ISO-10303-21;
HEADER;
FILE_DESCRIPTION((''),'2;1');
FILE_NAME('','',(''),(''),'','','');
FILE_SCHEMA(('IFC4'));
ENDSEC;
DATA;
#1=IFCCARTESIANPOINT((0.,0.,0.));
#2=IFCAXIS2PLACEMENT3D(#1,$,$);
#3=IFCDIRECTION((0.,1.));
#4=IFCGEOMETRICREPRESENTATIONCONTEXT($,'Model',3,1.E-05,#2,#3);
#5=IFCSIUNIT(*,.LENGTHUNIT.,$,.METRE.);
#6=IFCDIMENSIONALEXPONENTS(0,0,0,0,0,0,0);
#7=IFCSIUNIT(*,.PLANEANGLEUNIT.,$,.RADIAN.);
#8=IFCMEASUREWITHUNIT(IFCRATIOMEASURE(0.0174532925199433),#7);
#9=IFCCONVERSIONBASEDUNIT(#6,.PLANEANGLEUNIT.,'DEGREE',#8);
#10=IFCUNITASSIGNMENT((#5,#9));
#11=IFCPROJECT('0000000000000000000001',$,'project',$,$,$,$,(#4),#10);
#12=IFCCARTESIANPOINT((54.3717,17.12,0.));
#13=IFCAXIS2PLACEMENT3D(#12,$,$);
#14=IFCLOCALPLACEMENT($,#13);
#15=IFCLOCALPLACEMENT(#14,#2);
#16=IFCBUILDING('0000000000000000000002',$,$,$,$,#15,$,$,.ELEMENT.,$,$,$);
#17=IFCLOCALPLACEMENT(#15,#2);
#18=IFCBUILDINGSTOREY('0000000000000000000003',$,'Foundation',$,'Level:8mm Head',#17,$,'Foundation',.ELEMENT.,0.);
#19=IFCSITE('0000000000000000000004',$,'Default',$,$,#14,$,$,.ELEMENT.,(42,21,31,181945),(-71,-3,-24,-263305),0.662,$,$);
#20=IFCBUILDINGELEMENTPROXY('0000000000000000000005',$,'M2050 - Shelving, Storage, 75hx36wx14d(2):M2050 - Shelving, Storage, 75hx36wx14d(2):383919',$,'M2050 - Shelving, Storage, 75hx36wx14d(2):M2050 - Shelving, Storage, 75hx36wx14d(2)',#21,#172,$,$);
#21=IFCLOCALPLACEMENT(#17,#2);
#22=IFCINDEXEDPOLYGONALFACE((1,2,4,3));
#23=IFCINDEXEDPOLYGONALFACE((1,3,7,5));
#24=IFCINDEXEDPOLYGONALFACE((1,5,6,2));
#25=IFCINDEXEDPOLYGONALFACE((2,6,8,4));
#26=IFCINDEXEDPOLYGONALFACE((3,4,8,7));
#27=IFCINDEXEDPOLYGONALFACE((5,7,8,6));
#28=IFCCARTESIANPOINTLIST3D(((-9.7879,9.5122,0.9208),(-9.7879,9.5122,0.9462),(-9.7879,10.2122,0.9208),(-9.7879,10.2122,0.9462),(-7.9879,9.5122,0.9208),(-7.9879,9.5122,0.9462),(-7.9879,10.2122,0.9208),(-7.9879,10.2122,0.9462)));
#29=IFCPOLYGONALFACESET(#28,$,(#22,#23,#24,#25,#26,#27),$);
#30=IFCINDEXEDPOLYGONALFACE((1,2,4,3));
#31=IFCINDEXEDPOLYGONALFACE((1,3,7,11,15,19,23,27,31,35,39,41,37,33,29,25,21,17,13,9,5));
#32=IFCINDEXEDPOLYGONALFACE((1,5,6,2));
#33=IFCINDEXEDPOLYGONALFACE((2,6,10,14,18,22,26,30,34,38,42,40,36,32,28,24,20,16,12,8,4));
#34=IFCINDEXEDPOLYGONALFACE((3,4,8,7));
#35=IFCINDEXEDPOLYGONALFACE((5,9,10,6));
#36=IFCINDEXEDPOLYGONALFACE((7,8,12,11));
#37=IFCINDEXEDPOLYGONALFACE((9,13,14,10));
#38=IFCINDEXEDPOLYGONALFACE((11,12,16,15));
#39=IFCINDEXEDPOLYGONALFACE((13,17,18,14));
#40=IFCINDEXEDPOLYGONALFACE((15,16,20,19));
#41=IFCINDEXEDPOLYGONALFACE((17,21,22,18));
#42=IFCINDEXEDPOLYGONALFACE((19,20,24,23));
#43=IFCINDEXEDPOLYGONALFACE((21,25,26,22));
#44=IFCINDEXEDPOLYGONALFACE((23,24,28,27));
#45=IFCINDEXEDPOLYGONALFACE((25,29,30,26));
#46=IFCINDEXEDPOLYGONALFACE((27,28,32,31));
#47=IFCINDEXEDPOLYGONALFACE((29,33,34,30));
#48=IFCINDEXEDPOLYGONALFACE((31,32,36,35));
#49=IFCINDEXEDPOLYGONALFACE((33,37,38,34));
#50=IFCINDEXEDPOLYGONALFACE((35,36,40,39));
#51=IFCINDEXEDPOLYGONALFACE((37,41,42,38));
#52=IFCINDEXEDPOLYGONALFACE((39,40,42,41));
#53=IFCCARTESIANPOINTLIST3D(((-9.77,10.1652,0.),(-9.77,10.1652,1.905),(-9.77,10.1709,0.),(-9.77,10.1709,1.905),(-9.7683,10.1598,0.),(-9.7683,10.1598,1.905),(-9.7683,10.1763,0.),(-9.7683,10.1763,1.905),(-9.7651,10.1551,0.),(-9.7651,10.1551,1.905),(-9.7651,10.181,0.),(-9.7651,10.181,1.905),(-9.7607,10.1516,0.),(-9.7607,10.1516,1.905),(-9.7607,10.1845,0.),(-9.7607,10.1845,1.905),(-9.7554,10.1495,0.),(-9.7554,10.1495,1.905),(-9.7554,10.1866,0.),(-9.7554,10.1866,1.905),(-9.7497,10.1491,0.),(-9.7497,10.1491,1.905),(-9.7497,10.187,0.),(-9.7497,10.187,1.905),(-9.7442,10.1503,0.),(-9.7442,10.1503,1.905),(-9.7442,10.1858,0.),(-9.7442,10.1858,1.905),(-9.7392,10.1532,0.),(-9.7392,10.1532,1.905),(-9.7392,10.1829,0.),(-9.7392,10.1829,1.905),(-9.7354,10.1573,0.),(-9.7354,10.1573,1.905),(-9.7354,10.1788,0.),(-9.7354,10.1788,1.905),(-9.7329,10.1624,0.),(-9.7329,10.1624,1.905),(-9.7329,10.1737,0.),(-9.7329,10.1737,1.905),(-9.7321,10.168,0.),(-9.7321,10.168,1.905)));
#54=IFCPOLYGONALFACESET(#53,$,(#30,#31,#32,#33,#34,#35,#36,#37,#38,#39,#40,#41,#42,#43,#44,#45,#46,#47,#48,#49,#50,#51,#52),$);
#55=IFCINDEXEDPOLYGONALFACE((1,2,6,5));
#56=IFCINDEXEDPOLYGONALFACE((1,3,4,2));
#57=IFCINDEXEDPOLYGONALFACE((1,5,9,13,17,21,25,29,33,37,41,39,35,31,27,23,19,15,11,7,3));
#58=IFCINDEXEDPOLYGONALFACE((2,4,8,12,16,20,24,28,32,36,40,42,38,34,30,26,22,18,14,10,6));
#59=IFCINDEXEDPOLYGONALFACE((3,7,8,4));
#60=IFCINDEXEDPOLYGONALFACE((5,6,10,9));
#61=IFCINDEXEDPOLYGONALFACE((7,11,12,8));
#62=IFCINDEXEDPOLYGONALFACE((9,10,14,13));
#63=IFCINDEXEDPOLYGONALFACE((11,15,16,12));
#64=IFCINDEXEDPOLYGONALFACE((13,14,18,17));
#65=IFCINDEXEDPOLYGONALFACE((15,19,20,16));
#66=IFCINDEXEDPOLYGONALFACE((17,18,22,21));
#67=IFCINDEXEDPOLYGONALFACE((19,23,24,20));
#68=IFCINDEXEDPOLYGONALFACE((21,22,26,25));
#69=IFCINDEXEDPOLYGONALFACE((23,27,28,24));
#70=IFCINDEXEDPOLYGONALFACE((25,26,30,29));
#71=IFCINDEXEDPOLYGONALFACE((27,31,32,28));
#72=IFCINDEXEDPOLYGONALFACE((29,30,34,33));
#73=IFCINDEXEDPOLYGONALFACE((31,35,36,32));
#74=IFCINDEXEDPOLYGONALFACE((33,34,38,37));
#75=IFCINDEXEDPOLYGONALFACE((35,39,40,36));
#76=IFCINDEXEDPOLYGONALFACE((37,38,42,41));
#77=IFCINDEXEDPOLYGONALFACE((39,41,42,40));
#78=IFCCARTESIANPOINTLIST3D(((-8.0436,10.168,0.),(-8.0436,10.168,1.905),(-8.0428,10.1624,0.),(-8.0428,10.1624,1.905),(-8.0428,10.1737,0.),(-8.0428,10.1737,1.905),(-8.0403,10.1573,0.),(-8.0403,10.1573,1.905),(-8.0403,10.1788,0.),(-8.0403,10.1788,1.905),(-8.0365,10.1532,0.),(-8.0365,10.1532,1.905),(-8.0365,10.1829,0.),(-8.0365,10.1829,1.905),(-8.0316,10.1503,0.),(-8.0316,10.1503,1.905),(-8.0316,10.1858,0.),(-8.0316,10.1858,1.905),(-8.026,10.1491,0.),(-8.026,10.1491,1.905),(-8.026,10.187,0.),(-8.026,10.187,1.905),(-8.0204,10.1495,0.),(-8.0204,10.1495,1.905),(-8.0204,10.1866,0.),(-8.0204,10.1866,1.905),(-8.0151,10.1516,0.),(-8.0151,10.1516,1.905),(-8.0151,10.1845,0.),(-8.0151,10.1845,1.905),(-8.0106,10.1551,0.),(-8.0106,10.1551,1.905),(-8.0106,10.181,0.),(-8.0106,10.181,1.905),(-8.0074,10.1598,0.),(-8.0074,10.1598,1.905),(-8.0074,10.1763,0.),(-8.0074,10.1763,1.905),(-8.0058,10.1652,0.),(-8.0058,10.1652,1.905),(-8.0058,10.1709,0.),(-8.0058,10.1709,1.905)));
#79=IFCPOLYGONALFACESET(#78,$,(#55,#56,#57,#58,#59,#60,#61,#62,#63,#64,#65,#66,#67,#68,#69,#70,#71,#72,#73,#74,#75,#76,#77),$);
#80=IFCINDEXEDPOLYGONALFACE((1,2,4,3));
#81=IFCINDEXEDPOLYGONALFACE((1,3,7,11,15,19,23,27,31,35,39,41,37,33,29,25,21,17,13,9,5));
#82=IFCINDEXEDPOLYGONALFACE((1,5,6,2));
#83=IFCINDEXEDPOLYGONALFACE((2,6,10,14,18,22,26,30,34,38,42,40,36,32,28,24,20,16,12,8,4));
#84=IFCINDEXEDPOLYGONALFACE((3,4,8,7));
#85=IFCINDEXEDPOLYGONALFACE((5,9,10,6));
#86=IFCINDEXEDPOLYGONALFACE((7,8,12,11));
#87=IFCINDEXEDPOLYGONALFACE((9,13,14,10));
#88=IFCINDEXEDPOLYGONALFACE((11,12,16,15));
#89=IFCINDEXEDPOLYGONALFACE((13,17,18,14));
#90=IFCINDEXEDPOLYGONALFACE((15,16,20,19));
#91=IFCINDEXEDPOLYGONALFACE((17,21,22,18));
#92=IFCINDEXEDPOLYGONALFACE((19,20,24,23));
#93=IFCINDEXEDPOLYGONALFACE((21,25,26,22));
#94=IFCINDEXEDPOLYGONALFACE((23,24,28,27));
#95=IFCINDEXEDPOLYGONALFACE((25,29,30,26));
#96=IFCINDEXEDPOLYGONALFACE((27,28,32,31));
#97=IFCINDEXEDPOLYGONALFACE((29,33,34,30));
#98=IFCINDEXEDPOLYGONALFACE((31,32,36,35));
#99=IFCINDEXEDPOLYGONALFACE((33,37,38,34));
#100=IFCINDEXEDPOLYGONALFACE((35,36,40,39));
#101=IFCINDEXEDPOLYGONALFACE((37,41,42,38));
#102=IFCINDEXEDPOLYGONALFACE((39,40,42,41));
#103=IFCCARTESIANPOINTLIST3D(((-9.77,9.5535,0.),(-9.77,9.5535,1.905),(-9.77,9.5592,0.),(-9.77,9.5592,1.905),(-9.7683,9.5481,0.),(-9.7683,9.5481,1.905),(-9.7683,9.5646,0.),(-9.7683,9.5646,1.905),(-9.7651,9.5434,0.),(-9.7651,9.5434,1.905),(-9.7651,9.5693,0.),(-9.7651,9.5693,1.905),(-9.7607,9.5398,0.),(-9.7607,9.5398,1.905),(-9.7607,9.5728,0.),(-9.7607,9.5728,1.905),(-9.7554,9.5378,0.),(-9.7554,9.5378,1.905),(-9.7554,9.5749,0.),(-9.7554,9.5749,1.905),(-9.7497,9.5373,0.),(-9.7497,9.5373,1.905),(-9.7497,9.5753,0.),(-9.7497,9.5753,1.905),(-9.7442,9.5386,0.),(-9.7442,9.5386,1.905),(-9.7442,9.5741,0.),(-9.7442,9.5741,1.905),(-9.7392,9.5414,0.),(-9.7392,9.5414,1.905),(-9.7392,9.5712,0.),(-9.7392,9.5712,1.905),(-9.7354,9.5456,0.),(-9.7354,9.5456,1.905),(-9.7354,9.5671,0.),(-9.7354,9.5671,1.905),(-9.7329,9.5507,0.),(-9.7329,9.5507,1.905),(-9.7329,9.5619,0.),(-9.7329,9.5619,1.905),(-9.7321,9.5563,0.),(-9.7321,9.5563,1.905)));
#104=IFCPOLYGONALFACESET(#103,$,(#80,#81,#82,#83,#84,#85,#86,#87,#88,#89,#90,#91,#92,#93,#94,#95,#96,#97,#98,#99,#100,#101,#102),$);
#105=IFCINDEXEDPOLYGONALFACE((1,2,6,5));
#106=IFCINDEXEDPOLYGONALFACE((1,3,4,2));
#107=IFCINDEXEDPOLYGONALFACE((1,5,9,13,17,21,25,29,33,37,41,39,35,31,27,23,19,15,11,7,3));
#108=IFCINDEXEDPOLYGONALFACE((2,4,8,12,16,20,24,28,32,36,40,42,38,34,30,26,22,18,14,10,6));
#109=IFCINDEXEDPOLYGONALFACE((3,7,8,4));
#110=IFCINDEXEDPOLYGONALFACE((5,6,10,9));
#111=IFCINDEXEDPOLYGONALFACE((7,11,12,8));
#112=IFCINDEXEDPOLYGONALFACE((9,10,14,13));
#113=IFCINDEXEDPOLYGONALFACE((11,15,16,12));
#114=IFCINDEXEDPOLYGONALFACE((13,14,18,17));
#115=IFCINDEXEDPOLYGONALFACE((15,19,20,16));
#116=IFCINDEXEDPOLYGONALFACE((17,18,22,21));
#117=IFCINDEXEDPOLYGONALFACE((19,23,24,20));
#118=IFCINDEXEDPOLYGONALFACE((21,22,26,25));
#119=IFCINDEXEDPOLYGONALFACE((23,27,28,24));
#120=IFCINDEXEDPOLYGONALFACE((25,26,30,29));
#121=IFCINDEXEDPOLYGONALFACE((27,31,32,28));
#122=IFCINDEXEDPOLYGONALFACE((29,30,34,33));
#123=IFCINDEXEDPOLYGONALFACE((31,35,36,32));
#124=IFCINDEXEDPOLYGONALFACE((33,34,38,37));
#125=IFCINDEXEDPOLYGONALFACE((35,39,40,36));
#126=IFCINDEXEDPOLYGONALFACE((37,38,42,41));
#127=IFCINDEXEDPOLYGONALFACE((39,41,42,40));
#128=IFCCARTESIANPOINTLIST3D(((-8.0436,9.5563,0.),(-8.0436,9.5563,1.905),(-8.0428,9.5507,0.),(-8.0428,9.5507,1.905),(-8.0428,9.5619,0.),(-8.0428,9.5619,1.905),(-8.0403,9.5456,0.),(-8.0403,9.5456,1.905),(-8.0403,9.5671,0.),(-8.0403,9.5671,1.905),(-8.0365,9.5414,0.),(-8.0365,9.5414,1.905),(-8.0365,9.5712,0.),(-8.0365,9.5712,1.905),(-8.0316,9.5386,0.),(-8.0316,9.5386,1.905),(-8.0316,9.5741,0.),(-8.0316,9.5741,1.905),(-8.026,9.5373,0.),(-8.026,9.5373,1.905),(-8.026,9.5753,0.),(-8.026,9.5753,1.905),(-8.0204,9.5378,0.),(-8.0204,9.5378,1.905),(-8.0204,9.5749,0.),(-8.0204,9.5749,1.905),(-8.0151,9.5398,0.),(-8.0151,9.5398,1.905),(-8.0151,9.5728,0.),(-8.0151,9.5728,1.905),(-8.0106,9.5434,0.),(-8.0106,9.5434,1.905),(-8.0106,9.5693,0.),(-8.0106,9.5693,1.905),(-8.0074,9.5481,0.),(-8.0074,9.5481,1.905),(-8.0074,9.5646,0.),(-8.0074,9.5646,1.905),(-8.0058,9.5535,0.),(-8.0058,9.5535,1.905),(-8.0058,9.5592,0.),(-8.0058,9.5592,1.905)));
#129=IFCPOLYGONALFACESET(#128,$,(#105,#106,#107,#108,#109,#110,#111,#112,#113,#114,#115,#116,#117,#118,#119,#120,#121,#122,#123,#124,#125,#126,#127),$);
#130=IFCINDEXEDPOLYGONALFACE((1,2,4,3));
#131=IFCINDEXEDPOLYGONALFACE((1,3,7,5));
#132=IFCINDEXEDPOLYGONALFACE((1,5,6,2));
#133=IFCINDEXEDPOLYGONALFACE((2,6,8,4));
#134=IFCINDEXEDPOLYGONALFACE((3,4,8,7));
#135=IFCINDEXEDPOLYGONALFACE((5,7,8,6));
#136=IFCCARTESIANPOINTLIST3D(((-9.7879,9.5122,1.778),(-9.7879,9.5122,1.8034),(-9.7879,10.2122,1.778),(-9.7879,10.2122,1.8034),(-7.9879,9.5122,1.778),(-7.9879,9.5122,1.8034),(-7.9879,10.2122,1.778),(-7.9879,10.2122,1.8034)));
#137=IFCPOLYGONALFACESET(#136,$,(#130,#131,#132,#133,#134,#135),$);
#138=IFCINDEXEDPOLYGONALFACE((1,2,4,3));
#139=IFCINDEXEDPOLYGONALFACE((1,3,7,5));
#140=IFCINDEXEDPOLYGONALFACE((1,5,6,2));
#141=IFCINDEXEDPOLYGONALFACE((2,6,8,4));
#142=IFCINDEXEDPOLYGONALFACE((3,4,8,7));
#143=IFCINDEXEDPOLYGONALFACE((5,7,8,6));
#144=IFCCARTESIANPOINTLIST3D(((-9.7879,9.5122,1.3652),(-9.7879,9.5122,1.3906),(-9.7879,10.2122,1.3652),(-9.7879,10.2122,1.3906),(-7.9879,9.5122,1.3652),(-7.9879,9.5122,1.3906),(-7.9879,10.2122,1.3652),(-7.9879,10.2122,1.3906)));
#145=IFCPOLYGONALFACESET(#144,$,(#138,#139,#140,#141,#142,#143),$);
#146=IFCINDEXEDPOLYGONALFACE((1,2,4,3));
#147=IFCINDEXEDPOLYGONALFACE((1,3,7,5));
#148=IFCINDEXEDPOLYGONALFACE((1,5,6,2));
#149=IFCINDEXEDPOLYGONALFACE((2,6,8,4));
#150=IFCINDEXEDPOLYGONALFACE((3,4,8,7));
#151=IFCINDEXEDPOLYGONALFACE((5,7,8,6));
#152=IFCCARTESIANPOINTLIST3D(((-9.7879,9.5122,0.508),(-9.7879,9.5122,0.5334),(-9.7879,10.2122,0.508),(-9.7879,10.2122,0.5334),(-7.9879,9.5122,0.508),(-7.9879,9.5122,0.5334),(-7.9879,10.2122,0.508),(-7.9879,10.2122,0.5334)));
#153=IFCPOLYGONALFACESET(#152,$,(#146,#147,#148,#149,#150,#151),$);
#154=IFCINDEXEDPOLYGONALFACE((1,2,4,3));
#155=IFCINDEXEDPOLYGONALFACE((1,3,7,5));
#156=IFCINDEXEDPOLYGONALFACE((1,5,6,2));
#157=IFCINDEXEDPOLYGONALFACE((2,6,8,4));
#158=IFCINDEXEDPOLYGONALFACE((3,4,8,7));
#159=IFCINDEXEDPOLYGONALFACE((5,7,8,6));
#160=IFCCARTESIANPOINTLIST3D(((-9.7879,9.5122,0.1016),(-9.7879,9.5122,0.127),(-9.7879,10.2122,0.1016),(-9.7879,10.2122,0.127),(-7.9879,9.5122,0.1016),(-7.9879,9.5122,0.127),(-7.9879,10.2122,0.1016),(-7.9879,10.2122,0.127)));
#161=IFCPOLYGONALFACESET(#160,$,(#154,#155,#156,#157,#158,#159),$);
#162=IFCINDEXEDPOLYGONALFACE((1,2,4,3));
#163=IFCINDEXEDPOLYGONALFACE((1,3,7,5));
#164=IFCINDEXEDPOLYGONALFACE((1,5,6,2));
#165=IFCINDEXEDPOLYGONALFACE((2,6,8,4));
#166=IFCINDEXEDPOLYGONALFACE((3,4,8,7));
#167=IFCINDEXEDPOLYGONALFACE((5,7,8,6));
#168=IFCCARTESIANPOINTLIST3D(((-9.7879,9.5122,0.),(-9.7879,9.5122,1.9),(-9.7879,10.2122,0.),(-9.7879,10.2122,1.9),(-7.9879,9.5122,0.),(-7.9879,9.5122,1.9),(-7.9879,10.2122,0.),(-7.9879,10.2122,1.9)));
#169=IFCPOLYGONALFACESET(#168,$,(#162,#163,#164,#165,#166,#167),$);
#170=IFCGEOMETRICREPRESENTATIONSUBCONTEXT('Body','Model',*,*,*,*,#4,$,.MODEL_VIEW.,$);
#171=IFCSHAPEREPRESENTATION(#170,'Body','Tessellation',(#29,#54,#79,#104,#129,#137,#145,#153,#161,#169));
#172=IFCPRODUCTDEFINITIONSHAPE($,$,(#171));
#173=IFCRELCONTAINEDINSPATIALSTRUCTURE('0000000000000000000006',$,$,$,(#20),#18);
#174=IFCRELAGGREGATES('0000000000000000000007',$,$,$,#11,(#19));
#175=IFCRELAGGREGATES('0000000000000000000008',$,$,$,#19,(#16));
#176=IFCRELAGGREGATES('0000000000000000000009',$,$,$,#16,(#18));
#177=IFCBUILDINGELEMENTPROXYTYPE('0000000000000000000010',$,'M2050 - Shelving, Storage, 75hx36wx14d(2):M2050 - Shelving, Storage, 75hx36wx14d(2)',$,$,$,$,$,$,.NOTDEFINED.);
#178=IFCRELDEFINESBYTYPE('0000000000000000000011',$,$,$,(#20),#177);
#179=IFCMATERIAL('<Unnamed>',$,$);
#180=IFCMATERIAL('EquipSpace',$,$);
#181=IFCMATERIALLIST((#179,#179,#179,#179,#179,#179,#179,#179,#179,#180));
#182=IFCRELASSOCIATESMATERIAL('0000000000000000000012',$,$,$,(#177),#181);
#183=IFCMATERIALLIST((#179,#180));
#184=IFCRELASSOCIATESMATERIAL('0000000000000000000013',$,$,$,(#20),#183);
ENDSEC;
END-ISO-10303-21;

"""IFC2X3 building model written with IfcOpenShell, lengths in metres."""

from ifc_helpers import new_model, entity, si_unit, converted_unit, direction, frame, frame_2d, origin, origin_2d_with_axis, place, context, subcontext, project, spatial, rectangle, circle, extrude, source, transform, mapped, material, material_list, type_object, type_shapes, element, save


model = new_model("IFC2X3")

# Units and contexts
model_context = context("Model", 3, precision=1e-05, world=origin(), true_north=direction((0.0, 1.0)))
body_context = subcontext(model_context, "Body", "Model", "MODEL_VIEW")
ifc_project = project(units=[si_unit("LENGTHUNIT", "METRE"), converted_unit("PLANEANGLEUNIT", "DEGREE", entity("IfcRatioMeasure", 0.0174532925199433), si_unit("PLANEANGLEUNIT", "RADIAN"), dimensions=[0, 0, 0, 0, 0, 0, 0])], contexts=[model_context])

# Site, building, storey
site_placement = place(None, frame((54.3717, 17.12, 0.0)))
site = spatial("IfcSite", under=ifc_project, at=site_placement, Name="Default", CompositionType="ELEMENT", RefLatitude=(42, 21, 31, 181945), RefLongitude=(-71, -3, -24, -263305), RefElevation=0.662)
building_placement = place(site_placement, origin())
building = spatial("IfcBuilding", under=site, at=building_placement, CompositionType="ELEMENT")
storey_placement = place(building_placement, origin())
storey = spatial("IfcBuildingStorey", under=building, at=storey_placement, Name="Foundation", ObjectType="Level:8mm Head", LongName="Foundation", CompositionType="ELEMENT", Elevation=0.0)

# Building element proxy
ifc_material_1 = material(Name="<Unnamed>")
ifc_material_2 = material(Name="EquipSpace")
ifc_material_list_1 = material_list([ifc_material_1, ifc_material_1, ifc_material_1, ifc_material_1, ifc_material_1, ifc_material_1, ifc_material_1, ifc_material_1, ifc_material_1, ifc_material_2])
building_element_proxy_type = type_object("IfcBuildingElementProxyType", Name="M2050 - Shelving, Storage, 75hx36wx14d(2):M2050 - Shelving, Storage, 75hx36wx14d(2)", PredefinedType="NOTDEFINED", material=ifc_material_list_1)
shared_shape = source(origin(), body_context, "Body", "SweptSolid", [
    extrude(rectangle(XDim=1.8, YDim=0.7, at=origin_2d_with_axis()), frame((0.0, 0.0, 0.9207), z_axis=(0.0, 0.0, 1.0), x_axis=(-1.0, 0.0, 0.0)), (0.0, 0.0, 1.0), 0.0254),
    extrude(circle(Radius=0.0191, at=origin_2d_with_axis()), frame((0.8633, -0.3059, 0.0), z_axis=(0.0, 0.0, 1.0), x_axis=(-1.0, 0.0, 0.0)), (0.0, 0.0, 1.0), 1.905),
    extrude(circle(Radius=0.0191, at=origin_2d_with_axis()), frame((-0.8633, -0.3059, 0.0)), (0.0, 0.0, 1.0), 1.905),
    extrude(circle(Radius=0.0191, at=origin_2d_with_axis()), frame((0.8633, 0.3059, 0.0), z_axis=(0.0, 0.0, 1.0), x_axis=(-1.0, 0.0, 0.0)), (0.0, 0.0, 1.0), 1.905),
    extrude(circle(Radius=0.0191, at=origin_2d_with_axis()), frame((-0.8633, 0.3059, 0.0)), (0.0, 0.0, 1.0), 1.905),
    extrude(rectangle(XDim=1.8, YDim=0.7, at=origin_2d_with_axis()), frame((0.0, 0.0, 1.778), z_axis=(0.0, 0.0, 1.0), x_axis=(-1.0, 0.0, 0.0)), (0.0, 0.0, 1.0), 0.0254),
    extrude(rectangle(XDim=1.8, YDim=0.7, at=origin_2d_with_axis()), frame((0.0, 0.0, 1.3653), z_axis=(0.0, 0.0, 1.0), x_axis=(-1.0, 0.0, 0.0)), (0.0, 0.0, 1.0), 0.0254),
    extrude(rectangle(XDim=1.8, YDim=0.7, at=origin_2d_with_axis()), frame((0.0, 0.0, 0.508), z_axis=(0.0, 0.0, 1.0), x_axis=(-1.0, 0.0, 0.0)), (0.0, 0.0, 1.0), 0.0254),
    extrude(rectangle(XDim=1.8, YDim=0.7, at=origin_2d_with_axis()), frame((0.0, 0.0, 0.1016), z_axis=(0.0, 0.0, 1.0), x_axis=(-1.0, 0.0, 0.0)), (0.0, 0.0, 1.0), 0.0254),
    extrude(rectangle(XDim=0.7, YDim=1.8, at=frame_2d((0.0, 0.18), x_axis=(1.0, 0.0))), frame((-0.18, 0.0, 0.0), z_axis=(0.0, 0.0, 1.0), x_axis=(0.0, -1.0, 0.0)), (0.0, 0.0, 1.0), 1.9),
])
type_shapes(building_element_proxy_type, [shared_shape])
ifc_material_list_2 = material_list([ifc_material_1, ifc_material_2])
proxy_1_placement = place(storey_placement, frame((-8.8879, 9.8622, 0.0), z_axis=(0.0, 0.0, 1.0), x_axis=(-1.0, 0.0, 0.0)))
element("IfcBuildingElementProxy", 1, at=proxy_1_placement, inside=storey, type_object=building_element_proxy_type, material=ifc_material_list_2, Name="M2050 - Shelving, Storage, 75hx36wx14d(2):M2050 - Shelving, Storage, 75hx36wx14d(2):383919", ObjectType="M2050 - Shelving, Storage, 75hx36wx14d(2):M2050 - Shelving, Storage, 75hx36wx14d(2)", context=body_context, shape_type="MappedRepresentation", body=[
    mapped(shared_shape, transform((0.0, 0.0, 0.0), scale=1.0)),
])

save(model, "model.ifc")
